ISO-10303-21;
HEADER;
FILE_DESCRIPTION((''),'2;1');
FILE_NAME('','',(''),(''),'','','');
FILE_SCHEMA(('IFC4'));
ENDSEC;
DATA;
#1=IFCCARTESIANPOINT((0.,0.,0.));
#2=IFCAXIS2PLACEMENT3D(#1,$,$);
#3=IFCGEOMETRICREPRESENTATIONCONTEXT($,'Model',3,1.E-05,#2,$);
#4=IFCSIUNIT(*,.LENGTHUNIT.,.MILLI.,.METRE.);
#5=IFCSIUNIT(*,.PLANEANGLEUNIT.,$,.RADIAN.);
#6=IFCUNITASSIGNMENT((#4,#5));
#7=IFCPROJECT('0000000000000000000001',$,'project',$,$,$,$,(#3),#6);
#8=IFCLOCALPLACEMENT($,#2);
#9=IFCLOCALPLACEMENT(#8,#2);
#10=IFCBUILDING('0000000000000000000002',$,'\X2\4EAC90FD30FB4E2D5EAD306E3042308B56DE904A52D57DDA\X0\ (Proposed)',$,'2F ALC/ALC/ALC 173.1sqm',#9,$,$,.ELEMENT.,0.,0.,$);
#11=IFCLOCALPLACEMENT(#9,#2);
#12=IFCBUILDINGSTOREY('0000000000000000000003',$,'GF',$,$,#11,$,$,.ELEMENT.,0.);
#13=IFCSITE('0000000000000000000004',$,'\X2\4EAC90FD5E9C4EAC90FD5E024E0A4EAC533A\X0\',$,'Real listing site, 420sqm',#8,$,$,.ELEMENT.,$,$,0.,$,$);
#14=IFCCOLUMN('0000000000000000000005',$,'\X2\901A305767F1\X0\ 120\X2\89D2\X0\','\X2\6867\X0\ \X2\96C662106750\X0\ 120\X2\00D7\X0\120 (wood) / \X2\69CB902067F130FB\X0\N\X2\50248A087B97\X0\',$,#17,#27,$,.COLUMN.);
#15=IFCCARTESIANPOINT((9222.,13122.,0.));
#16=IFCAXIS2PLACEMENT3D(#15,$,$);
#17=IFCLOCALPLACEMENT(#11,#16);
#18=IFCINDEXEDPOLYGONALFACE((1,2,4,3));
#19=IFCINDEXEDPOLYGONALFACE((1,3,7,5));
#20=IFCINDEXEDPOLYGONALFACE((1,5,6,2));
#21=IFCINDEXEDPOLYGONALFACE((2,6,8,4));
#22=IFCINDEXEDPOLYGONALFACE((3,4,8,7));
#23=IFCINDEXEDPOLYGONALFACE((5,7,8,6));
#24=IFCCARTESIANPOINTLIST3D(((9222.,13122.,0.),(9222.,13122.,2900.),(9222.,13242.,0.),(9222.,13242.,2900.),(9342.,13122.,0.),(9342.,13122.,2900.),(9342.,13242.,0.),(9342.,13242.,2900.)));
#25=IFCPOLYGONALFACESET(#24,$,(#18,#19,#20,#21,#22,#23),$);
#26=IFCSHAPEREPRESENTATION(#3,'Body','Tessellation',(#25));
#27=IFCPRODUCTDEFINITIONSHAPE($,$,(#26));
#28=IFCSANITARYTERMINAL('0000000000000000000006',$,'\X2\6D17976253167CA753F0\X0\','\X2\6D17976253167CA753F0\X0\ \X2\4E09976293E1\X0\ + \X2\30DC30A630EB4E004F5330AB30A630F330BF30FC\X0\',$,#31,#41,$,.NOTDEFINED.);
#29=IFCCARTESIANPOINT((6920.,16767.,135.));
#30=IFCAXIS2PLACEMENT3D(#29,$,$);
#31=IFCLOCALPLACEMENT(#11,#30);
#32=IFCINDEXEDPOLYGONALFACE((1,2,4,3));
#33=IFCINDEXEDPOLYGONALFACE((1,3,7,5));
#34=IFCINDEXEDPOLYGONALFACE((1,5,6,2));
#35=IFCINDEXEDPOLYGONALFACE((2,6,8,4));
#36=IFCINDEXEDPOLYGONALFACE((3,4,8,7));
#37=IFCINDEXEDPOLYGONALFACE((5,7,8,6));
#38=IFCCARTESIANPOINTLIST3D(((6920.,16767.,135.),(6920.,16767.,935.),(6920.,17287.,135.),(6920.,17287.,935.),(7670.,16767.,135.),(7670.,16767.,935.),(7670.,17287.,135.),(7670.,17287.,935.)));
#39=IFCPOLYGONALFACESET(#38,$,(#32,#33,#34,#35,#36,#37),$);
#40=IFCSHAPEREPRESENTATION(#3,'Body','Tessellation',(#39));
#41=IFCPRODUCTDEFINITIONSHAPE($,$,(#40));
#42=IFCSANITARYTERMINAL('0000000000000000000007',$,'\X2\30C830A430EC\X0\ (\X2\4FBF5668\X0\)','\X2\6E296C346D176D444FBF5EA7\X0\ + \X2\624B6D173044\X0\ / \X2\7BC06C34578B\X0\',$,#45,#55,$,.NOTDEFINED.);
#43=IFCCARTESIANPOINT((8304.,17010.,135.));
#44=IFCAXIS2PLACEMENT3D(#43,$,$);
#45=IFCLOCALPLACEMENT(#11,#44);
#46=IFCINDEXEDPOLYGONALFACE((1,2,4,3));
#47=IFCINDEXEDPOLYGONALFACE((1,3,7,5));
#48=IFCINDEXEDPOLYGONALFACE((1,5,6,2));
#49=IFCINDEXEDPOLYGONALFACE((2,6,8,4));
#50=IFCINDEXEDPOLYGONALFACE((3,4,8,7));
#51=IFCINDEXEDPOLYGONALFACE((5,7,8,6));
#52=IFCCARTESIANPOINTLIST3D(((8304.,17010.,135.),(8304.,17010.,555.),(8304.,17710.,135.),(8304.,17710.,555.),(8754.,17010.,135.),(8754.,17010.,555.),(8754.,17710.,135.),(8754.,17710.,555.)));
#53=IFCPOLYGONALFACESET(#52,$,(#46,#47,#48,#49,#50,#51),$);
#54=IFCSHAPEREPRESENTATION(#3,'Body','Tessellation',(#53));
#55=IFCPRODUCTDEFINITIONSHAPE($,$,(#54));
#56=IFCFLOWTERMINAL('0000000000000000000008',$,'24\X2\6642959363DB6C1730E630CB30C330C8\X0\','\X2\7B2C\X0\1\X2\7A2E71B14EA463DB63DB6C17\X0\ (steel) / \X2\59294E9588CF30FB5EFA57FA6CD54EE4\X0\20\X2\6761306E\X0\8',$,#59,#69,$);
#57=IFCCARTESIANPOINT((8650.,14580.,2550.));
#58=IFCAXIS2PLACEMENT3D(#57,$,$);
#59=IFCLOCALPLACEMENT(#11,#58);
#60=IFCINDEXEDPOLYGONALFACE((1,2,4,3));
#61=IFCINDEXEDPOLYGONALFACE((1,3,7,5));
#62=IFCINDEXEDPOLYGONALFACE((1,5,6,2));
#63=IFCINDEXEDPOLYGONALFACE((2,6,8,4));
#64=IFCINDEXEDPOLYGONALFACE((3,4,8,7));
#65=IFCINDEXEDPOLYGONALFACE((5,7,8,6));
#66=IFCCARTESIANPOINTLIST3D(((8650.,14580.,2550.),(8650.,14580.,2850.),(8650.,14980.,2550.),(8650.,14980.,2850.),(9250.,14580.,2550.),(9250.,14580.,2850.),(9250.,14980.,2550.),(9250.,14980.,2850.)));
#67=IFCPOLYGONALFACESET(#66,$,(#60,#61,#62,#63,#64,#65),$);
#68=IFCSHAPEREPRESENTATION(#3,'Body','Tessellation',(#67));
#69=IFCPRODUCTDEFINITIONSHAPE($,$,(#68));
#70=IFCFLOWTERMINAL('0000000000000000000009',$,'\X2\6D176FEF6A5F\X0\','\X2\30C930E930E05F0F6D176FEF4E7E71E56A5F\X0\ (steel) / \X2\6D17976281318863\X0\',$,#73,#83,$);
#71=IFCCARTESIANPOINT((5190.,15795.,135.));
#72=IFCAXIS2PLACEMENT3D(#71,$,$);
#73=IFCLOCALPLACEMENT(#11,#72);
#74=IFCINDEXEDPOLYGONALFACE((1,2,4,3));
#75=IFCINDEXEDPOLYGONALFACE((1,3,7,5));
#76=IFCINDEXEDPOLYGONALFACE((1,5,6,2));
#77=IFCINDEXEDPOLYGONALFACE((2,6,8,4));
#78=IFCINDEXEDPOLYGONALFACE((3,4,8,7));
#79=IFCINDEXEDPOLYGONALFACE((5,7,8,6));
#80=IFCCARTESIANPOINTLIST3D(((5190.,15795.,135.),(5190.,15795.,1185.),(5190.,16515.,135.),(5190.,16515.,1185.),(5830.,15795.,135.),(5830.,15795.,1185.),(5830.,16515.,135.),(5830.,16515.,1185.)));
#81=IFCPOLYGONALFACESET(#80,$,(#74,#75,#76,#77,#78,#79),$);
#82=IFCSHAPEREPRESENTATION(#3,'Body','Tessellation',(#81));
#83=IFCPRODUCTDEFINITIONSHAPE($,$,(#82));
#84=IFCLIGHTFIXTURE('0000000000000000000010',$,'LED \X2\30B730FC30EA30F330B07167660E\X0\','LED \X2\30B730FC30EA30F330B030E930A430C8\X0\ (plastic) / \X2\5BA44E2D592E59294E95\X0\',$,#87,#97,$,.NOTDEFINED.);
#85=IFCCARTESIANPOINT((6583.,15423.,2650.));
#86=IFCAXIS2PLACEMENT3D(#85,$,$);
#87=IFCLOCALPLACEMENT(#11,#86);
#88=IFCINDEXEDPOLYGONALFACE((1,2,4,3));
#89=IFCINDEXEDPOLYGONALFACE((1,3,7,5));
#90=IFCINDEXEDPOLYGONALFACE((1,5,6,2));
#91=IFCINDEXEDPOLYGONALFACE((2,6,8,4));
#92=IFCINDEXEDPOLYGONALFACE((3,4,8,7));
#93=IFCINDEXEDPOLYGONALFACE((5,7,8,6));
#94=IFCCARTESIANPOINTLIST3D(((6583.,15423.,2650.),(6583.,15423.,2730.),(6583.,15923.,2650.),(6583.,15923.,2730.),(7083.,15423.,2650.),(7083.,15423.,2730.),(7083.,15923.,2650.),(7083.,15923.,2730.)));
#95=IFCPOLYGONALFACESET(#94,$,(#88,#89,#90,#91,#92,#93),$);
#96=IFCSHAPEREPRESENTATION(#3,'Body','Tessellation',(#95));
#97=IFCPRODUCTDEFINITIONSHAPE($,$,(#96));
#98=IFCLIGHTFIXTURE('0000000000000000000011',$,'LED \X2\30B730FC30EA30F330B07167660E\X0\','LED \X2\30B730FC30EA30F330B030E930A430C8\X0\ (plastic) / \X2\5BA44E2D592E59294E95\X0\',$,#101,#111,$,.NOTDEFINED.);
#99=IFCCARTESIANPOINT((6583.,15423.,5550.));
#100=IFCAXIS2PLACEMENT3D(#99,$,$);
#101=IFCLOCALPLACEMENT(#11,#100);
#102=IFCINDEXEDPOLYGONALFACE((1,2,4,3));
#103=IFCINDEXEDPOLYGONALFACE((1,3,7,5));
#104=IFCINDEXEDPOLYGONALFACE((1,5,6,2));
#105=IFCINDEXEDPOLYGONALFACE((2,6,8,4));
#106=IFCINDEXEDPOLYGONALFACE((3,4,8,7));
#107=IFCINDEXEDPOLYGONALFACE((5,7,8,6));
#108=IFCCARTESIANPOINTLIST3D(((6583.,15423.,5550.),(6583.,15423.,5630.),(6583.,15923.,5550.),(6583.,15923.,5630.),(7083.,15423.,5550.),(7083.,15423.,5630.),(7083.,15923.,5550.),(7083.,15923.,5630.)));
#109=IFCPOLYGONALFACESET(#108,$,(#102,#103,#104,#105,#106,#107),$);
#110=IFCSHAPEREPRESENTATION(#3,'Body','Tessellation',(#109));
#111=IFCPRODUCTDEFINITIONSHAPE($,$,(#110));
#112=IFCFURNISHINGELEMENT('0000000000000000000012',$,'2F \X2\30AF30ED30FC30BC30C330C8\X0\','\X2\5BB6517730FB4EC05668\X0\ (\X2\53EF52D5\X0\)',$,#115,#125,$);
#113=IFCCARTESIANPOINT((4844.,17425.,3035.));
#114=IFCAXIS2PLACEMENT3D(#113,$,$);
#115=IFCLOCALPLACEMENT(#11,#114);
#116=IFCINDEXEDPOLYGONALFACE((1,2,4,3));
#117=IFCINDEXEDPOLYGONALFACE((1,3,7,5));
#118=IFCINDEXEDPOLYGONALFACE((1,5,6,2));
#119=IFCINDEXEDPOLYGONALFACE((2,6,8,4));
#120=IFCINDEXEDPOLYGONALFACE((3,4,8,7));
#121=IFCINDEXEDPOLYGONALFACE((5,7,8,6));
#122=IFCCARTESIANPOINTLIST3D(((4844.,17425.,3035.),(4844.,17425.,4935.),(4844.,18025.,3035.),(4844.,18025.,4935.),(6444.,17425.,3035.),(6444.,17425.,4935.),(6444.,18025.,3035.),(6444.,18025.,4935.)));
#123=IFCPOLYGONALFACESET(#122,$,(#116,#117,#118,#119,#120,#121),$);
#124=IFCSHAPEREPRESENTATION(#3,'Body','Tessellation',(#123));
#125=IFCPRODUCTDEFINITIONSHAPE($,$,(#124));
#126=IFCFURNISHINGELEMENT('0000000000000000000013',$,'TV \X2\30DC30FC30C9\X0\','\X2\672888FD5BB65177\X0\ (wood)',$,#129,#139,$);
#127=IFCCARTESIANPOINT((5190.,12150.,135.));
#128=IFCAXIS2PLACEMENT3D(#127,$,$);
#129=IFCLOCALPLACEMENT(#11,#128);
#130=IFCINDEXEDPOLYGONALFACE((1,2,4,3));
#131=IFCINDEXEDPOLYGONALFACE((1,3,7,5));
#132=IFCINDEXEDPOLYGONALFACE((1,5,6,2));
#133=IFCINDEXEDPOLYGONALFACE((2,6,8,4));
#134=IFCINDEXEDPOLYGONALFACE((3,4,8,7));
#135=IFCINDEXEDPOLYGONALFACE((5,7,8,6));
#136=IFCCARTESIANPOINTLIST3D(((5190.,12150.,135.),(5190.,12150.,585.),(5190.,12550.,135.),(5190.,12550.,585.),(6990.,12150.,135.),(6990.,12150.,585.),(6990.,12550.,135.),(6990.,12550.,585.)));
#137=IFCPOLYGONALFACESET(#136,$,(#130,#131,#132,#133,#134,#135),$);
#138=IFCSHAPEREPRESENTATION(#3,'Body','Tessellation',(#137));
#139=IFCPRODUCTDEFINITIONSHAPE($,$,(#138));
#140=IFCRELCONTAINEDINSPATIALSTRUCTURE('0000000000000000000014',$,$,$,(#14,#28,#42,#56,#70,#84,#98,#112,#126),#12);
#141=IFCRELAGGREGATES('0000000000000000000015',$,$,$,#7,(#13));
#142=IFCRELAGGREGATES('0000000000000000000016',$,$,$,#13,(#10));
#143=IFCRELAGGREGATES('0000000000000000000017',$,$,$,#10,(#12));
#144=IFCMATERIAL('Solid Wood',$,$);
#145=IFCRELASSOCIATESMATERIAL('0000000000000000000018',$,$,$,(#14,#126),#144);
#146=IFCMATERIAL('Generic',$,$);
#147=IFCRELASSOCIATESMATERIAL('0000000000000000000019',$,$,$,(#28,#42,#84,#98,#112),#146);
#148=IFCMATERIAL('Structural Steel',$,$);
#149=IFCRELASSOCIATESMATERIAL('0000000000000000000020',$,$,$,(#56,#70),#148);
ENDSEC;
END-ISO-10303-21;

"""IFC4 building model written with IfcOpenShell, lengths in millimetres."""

from ifc_helpers import new_model, si_unit, frame, frame_2d, origin, place, context, project, spatial, rectangle, extrude, material, element, save


model = new_model("IFC4")

# Units and contexts
model_context = context("Model", 3, precision=1e-05, world=origin())
ifc_project = project(units=[si_unit("LENGTHUNIT", "METRE", prefix="MILLI"), si_unit("PLANEANGLEUNIT", "RADIAN")], contexts=[model_context])

# Site, building, storey
site_placement = place(None, origin())
site = spatial("IfcSite", under=ifc_project, at=site_placement, Name="京都府京都市上京区", ObjectType="Real listing site, 420sqm", CompositionType="ELEMENT", RefElevation=0.0)
building_placement = place(site_placement, origin())
building = spatial("IfcBuilding", under=site, at=building_placement, Name="京都・中庭のある回遊動線 (Proposed)", ObjectType="2F ALC/ALC/ALC 173.1sqm", CompositionType="ELEMENT", ElevationOfRefHeight=0.0, ElevationOfTerrain=0.0)
storey_placement = place(building_placement, origin())
storey = spatial("IfcBuildingStorey", under=building, at=storey_placement, Name="GF", CompositionType="ELEMENT", Elevation=0.0)

# Column
ifc_material_1 = material(Name="Solid Wood")
column_1_placement = place(storey_placement, frame((9222.0, 13122.0, 0.0)))
element("IfcColumn", 1, at=column_1_placement, inside=storey, material=ifc_material_1, Name="通し柱 120角", Description="桧 集成材 120×120 (wood) / 構造柱・N値計算", PredefinedType="COLUMN", context=model_context, shape_type="SweptSolid", body=[
    extrude(rectangle(XDim=120.0, YDim=120.0, at=frame_2d((60.0, 60.0))), frame((9222.0, 13122.0, 0.0)), (0.0, 0.0, 1.0), 2900.0),
])

# Sanitary terminals
ifc_material_2 = material(Name="Generic")
sanitary_terminal_1_placement = place(storey_placement, frame((6920.0, 16767.0, 135.0)))
element("IfcSanitaryTerminal", 2, at=sanitary_terminal_1_placement, inside=storey, material=ifc_material_2, Name="洗面化粧台", Description="洗面化粧台 三面鏡 + ボウル一体カウンター", PredefinedType="NOTDEFINED", context=model_context, shape_type="SweptSolid", body=[
    extrude(rectangle(XDim=750.0, YDim=520.0, at=frame_2d((375.0, 260.0))), frame((6920.0, 16767.0, 135.0)), (0.0, 0.0, 1.0), 800.0),
])
sanitary_terminal_2_placement = place(storey_placement, frame((8304.0, 17010.0, 135.0)))
element("IfcSanitaryTerminal", 3, at=sanitary_terminal_2_placement, inside=storey, material=ifc_material_2, Name="トイレ (便器)", Description="温水洗浄便座 + 手洗い / 節水型", PredefinedType="NOTDEFINED", context=model_context, shape_type="SweptSolid", body=[
    extrude(rectangle(XDim=450.0, YDim=700.0, at=frame_2d((225.0, 350.0))), frame((8304.0, 17010.0, 135.0)), (0.0, 0.0, 1.0), 420.0),
])

# Flow terminals
ifc_material_3 = material(Name="Structural Steel")
flow_terminal_1_placement = place(storey_placement, frame((8650.0, 14580.0, 2550.0)))
element("IfcFlowTerminal", 4, at=flow_terminal_1_placement, inside=storey, material=ifc_material_3, Name="24時間換気ユニット", Description="第1種熱交換換気 (steel) / 天井裏・建基法令20条の8", context=model_context, shape_type="SweptSolid", body=[
    extrude(rectangle(XDim=600.0, YDim=400.0, at=frame_2d((300.0, 200.0))), frame((8650.0, 14580.0, 2550.0)), (0.0, 0.0, 1.0), 300.0),
])
flow_terminal_2_placement = place(storey_placement, frame((5190.0, 15795.0, 135.0)))
element("IfcFlowTerminal", 5, at=flow_terminal_2_placement, inside=storey, material=ifc_material_3, Name="洗濯機", Description="ドラム式洗濯乾燥機 (steel) / 洗面脱衣", context=model_context, shape_type="SweptSolid", body=[
    extrude(rectangle(XDim=640.0, YDim=720.0, at=frame_2d((320.0, 360.0))), frame((5190.0, 15795.0, 135.0)), (0.0, 0.0, 1.0), 1050.0),
])

# Light fixtures
light_fixture_1_placement = place(storey_placement, frame((6583.0, 15423.0, 2650.0)))
element("IfcLightFixture", 6, at=light_fixture_1_placement, inside=storey, material=ifc_material_2, Name="LED シーリング照明", Description="LED シーリングライト (plastic) / 室中央天井", PredefinedType="NOTDEFINED", context=model_context, shape_type="SweptSolid", body=[
    extrude(rectangle(XDim=500.0, YDim=500.0, at=frame_2d((250.0, 250.0))), frame((6583.0, 15423.0, 2650.0)), (0.0, 0.0, 1.0), 80.0),
])
light_fixture_2_placement = place(storey_placement, frame((6583.0, 15423.0, 5550.0)))
element("IfcLightFixture", 7, at=light_fixture_2_placement, inside=storey, material=ifc_material_2, Name="LED シーリング照明", Description="LED シーリングライト (plastic) / 室中央天井", PredefinedType="NOTDEFINED", context=model_context, shape_type="SweptSolid", body=[
    extrude(rectangle(XDim=500.0, YDim=500.0, at=frame_2d((250.0, 250.0))), frame((6583.0, 15423.0, 5550.0)), (0.0, 0.0, 1.0), 80.0),
])

# Furnishing elements
furnishing_1_placement = place(storey_placement, frame((4844.0, 17425.0, 3035.0)))
element("IfcFurnishingElement", 8, at=furnishing_1_placement, inside=storey, material=ifc_material_2, Name="2F クローゼット", Description="家具・什器 (可動)", context=model_context, shape_type="SweptSolid", body=[
    extrude(rectangle(XDim=1600.0, YDim=600.0, at=frame_2d((800.0, 300.0))), frame((4844.0, 17425.0, 3035.0)), (0.0, 0.0, 1.0), 1900.0),
])
furnishing_2_placement = place(storey_placement, frame((5190.0, 12150.0, 135.0)))
element("IfcFurnishingElement", 9, at=furnishing_2_placement, inside=storey, material=ifc_material_1, Name="TV ボード", Description="木製家具 (wood)", context=model_context, shape_type="SweptSolid", body=[
    extrude(rectangle(XDim=1800.0, YDim=400.0, at=frame_2d((900.0, 200.0))), frame((5190.0, 12150.0, 135.0)), (0.0, 0.0, 1.0), 450.0),
])

save(model, "model.ifc")
